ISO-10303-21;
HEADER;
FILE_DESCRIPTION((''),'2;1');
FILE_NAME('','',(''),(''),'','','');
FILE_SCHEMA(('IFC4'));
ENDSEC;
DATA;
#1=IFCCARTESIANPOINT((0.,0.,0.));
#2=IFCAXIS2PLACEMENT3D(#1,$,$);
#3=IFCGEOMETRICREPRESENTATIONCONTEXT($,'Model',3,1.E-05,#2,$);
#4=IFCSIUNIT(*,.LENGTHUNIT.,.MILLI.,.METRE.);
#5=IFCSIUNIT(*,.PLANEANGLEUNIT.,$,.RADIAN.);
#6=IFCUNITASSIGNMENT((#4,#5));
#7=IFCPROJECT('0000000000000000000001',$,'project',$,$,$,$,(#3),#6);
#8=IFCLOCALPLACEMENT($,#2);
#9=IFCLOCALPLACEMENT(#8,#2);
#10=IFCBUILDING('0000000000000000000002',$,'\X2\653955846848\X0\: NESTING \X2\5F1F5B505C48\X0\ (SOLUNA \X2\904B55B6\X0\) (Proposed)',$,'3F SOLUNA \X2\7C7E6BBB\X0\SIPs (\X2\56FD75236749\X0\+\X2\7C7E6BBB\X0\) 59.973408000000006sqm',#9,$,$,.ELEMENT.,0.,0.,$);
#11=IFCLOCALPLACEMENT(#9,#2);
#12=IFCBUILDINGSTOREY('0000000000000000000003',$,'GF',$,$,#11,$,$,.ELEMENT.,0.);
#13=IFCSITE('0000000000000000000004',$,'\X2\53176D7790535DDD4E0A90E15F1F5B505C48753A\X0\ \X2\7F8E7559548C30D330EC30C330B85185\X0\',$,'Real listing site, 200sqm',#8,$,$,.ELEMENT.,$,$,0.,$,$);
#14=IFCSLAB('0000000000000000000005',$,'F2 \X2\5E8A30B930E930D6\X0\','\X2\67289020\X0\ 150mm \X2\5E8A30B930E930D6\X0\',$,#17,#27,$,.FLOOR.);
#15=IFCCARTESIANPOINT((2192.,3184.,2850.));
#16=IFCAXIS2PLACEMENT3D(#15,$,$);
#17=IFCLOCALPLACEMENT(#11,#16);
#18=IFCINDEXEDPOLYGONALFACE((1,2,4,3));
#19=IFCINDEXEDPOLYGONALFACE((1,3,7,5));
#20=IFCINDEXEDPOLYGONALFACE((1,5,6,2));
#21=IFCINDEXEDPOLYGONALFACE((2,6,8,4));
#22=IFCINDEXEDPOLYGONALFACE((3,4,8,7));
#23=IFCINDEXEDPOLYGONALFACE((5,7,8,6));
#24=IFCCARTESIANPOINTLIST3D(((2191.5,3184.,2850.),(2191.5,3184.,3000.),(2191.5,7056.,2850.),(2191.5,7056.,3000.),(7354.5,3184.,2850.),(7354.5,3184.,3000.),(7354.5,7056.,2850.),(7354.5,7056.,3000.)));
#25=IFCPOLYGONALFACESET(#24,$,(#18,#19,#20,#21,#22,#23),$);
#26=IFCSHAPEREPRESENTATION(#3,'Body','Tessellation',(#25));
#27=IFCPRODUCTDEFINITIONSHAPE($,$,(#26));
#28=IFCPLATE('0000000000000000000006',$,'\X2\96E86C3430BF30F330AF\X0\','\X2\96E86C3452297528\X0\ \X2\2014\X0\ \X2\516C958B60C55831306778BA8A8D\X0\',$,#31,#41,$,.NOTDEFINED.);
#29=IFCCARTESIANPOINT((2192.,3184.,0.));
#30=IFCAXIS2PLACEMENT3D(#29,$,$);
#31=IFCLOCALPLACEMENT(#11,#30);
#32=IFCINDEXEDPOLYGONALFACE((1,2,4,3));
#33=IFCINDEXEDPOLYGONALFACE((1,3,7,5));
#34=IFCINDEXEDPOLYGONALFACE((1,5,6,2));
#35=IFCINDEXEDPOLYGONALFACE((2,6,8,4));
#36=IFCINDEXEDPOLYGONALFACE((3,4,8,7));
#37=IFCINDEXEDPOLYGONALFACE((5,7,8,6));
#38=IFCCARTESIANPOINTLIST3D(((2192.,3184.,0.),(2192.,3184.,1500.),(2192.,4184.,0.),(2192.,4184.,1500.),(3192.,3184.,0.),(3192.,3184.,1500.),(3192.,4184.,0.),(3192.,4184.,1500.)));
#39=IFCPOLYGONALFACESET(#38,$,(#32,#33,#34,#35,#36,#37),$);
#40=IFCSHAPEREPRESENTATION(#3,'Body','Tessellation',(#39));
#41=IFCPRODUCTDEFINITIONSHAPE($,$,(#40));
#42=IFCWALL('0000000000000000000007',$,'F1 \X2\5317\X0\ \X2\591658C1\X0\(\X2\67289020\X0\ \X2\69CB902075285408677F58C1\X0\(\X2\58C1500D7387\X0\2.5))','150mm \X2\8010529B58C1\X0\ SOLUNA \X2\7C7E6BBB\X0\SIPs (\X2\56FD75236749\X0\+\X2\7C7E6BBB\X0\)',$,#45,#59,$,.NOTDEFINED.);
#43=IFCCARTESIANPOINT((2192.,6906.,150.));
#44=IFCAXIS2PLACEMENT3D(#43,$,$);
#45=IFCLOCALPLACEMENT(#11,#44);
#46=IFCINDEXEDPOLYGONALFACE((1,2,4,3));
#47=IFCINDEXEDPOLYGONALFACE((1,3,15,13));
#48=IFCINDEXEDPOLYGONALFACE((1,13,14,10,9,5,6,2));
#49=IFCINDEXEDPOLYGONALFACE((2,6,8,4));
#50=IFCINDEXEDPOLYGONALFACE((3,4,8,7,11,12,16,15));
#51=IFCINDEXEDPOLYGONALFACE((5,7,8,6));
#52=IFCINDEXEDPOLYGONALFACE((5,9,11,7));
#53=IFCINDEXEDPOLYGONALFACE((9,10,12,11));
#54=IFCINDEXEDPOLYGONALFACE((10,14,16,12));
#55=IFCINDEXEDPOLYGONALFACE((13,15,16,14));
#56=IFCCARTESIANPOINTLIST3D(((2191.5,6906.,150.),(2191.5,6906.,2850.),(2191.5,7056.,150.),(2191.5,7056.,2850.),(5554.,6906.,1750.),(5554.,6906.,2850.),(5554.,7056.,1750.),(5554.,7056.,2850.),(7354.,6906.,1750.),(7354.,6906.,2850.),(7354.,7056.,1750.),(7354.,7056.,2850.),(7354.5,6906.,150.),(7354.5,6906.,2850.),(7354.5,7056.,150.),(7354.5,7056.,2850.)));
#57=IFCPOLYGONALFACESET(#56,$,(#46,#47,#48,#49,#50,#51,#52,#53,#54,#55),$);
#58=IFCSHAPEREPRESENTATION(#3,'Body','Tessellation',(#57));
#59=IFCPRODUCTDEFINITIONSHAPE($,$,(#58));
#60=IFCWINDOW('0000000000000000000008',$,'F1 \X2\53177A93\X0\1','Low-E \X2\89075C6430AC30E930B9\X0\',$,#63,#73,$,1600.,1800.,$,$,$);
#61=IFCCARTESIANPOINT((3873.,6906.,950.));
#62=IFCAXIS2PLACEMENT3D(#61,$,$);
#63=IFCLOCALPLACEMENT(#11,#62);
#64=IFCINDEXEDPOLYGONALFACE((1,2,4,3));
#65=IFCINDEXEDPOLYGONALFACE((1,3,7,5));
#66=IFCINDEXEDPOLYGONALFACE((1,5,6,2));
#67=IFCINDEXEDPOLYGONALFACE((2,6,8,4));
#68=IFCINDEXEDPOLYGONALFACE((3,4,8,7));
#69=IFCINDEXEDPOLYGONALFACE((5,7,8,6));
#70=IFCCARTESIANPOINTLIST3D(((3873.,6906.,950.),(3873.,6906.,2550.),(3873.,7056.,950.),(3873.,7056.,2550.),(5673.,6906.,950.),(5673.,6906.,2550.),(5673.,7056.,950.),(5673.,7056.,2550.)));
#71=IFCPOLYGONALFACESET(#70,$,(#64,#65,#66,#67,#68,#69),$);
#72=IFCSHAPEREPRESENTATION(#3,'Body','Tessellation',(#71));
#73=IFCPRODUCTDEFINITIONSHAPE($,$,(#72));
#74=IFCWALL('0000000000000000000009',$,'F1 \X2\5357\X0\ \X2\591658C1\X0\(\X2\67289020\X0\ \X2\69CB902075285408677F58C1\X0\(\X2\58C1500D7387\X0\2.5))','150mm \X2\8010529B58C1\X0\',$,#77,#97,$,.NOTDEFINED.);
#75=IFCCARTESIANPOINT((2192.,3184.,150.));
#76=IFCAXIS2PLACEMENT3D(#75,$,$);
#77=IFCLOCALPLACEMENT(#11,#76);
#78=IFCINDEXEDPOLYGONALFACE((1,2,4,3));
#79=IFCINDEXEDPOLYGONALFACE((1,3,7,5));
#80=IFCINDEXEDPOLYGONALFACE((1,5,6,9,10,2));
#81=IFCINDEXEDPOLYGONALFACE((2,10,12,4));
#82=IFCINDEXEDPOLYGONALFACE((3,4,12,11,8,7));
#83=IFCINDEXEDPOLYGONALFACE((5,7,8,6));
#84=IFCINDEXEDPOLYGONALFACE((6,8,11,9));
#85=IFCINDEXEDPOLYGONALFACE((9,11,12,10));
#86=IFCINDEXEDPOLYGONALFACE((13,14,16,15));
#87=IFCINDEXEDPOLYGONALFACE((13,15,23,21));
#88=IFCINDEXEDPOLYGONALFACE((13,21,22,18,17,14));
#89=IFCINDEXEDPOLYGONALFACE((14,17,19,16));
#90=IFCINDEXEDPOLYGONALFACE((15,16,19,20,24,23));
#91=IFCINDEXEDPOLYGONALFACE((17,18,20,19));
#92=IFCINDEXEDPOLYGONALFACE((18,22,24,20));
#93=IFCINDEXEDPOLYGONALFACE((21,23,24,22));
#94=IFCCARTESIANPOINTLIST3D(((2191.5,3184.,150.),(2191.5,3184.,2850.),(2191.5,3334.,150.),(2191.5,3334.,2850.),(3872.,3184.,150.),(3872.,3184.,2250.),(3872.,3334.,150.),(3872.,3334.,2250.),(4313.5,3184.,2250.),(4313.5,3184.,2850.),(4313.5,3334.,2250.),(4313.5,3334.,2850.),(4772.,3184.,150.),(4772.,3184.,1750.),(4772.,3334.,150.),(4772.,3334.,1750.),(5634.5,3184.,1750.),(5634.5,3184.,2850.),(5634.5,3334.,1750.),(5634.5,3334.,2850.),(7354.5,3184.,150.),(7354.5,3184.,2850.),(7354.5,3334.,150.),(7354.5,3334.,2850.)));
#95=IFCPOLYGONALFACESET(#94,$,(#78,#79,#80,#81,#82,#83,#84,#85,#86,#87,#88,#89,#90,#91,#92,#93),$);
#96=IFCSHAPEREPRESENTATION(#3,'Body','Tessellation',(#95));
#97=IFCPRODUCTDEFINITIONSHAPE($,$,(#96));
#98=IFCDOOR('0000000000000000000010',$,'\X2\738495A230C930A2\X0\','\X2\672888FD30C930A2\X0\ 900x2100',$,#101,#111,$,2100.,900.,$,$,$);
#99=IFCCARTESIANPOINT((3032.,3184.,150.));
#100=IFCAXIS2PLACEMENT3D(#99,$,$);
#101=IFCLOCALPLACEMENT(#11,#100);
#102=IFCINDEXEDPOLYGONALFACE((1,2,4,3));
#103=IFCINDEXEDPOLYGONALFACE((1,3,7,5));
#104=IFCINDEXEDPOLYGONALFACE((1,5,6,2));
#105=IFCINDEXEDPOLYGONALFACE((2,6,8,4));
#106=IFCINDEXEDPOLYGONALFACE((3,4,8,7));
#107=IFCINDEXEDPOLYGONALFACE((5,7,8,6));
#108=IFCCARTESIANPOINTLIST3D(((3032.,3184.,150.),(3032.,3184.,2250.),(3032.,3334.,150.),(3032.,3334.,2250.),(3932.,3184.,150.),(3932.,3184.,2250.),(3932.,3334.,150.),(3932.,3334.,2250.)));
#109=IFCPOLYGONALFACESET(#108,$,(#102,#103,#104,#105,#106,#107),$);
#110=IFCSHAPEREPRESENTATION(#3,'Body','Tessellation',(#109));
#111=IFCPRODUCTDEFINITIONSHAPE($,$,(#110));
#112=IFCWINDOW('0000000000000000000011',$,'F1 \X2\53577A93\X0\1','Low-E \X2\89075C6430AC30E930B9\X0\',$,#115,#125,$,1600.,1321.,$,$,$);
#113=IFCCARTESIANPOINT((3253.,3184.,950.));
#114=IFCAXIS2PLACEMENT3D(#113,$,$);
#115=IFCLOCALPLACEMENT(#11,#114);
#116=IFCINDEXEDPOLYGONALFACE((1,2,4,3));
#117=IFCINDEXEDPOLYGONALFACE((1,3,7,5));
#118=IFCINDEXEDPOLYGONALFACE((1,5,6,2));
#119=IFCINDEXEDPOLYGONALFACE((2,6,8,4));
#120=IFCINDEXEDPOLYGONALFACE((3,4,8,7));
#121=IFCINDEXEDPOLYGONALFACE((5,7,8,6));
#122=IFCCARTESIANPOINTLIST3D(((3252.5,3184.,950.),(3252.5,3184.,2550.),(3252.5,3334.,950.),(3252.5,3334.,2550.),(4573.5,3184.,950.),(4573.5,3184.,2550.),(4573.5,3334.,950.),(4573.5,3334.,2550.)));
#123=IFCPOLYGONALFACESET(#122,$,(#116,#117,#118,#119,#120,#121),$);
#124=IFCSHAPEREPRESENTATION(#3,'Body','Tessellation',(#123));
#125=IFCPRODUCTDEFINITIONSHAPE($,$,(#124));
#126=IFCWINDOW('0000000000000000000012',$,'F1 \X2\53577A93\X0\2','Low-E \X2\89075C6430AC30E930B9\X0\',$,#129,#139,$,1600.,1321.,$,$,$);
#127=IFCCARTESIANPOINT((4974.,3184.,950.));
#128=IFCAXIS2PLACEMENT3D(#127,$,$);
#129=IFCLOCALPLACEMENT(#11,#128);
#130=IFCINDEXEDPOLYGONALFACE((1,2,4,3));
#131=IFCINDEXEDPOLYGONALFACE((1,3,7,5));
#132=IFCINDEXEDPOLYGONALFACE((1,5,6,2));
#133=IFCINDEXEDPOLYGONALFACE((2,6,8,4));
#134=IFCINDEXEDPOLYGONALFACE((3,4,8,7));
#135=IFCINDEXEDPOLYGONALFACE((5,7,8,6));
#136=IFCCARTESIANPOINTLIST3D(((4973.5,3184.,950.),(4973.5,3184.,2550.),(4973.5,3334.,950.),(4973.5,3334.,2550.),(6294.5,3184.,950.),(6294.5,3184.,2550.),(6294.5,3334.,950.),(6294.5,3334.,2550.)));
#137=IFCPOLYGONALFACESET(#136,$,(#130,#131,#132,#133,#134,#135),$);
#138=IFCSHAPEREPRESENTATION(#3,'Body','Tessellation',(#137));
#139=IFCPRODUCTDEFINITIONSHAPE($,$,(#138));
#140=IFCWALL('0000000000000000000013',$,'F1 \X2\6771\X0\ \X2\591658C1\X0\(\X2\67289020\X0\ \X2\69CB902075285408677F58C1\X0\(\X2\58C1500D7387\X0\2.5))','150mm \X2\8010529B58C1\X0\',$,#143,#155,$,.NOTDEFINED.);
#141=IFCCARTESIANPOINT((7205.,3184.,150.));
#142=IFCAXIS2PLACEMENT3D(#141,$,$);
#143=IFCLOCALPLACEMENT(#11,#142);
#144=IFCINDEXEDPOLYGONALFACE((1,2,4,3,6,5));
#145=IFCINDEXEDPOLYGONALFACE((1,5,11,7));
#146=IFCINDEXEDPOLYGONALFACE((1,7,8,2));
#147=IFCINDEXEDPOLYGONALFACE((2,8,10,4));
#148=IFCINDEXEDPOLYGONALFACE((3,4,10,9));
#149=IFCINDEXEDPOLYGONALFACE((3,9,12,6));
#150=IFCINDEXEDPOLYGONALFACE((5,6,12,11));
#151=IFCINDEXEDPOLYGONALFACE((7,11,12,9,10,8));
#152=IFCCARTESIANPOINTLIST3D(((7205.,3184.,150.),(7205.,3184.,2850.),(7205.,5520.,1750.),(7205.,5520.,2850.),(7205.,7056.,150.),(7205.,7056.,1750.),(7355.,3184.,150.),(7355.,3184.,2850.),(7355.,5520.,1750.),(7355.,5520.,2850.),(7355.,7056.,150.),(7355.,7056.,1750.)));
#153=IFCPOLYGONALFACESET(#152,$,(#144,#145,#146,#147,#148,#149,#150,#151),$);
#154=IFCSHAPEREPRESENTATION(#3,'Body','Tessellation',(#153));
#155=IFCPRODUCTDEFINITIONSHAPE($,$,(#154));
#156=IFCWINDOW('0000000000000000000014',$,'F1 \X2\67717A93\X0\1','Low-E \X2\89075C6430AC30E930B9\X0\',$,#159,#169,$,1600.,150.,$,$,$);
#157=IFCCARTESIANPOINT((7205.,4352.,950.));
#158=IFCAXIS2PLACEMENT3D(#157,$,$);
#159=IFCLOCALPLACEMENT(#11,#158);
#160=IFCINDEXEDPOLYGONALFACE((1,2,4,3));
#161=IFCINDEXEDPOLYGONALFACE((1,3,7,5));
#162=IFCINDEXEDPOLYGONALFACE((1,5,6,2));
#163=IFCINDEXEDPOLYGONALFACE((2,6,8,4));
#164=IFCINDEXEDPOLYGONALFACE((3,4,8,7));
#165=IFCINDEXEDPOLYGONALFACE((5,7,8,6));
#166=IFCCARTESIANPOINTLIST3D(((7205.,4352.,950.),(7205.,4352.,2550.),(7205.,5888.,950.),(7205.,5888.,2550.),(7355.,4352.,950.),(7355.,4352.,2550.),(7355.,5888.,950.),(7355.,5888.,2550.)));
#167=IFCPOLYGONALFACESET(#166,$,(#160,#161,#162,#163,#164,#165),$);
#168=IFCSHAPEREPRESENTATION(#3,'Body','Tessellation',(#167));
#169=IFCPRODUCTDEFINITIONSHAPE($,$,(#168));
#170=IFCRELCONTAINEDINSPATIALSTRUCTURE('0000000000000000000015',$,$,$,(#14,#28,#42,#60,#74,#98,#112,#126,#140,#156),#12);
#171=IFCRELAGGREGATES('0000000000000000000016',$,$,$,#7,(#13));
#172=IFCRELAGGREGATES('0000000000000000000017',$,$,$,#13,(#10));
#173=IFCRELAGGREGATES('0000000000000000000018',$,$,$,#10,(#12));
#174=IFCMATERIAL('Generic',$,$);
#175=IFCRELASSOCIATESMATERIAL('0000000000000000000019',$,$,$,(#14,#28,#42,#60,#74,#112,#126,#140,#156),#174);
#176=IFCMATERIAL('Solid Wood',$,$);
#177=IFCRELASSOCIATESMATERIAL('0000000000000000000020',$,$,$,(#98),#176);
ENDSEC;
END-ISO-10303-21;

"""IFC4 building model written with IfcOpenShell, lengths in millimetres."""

from ifc_helpers import new_model, si_unit, frame, frame_2d, origin, place, context, project, spatial, rectangle, extrude, material, element, fill, save


model = new_model("IFC4")

# Units and contexts
model_context = context("Model", 3, precision=1e-05, world=origin())
ifc_project = project(units=[si_unit("LENGTHUNIT", "METRE", prefix="MILLI"), si_unit("PLANEANGLEUNIT", "RADIAN")], contexts=[model_context])

# Site, building, storey
site_placement = place(None, origin())
site = spatial("IfcSite", under=ifc_project, at=site_placement, Name="北海道川上郡弟子屈町 美留和ビレッジ内", ObjectType="Real listing site, 200sqm", CompositionType="ELEMENT", RefElevation=0.0)
building_placement = place(site_placement, origin())
building = spatial("IfcBuilding", under=site, at=building_placement, Name="改善案: NESTING 弟子屈 (SOLUNA 運営) (Proposed)", ObjectType="3F SOLUNA 籾殻SIPs (国産杉+籾殻) 59.973408000000006sqm", CompositionType="ELEMENT", ElevationOfRefHeight=0.0, ElevationOfTerrain=0.0)
storey_placement = place(building_placement, origin())
storey = spatial("IfcBuildingStorey", under=building, at=storey_placement, Name="GF", CompositionType="ELEMENT", Elevation=0.0)

# Slab
ifc_material_1 = material(Name="Generic")
slab_1_placement = place(storey_placement, frame((2192.0, 3184.0, 2850.0)))
element("IfcSlab", 1, at=slab_1_placement, inside=storey, material=ifc_material_1, Name="F2 床スラブ", Description="木造 150mm 床スラブ", PredefinedType="FLOOR", context=model_context, shape_type="SweptSolid", body=[
    extrude(rectangle(XDim=5163.0, YDim=3872.0, at=frame_2d((2581.0, 1936.0))), frame((2192.0, 3184.0, 2850.0)), (0.0, 0.0, 1.0), 150.0),
])

# Plate
plate_placement = place(storey_placement, frame((2192.0, 3184.0, 0.0)))
element("IfcPlate", 2, at=plate_placement, inside=storey, material=ifc_material_1, Name="雨水タンク", Description="雨水利用 — 公開情報で確認", PredefinedType="NOTDEFINED", context=model_context, shape_type="SweptSolid", body=[
    extrude(rectangle(XDim=1000.0, YDim=1000.0, at=frame_2d((500.0, 500.0))), frame((2192.0, 3184.0, 0.0)), (0.0, 0.0, 1.0), 1500.0),
])

# Wall, opening, window
wall_1_placement = place(storey_placement, frame((2192.0, 6906.0, 150.0)))
wall_1 = element("IfcWall", 3, at=wall_1_placement, inside=storey, material=ifc_material_1, Name="F1 北 外壁(木造 構造用合板壁(壁倍率2.5))", Description="150mm 耐力壁 SOLUNA 籾殻SIPs (国産杉+籾殻)", PredefinedType="NOTDEFINED", context=model_context, shape_type="SweptSolid", body=[
    extrude(rectangle(XDim=5163.0, YDim=150.0, at=frame_2d((2581.0, 75.0))), frame((2192.0, 6906.0, 150.0)), (0.0, 0.0, 1.0), 2700.0),
])
opening_1_placement = place(storey_placement, frame((3873.0, 6906.0, 950.0)))
opening_1 = element("IfcOpeningElement", 4, at=opening_1_placement, cuts=wall_1, PredefinedType="NOTDEFINED", context=model_context, shape_type="SweptSolid", body=[
    extrude(rectangle(XDim=1800.0, YDim=150.0, at=frame_2d((900.0, 75.0))), frame((3873.0, 6906.0, 950.0)), (0.0, 0.0, 1.0), 1600.0),
])
window_1_placement = place(storey_placement, frame((3873.0, 6906.0, 950.0)))
window_1 = element("IfcWindow", 5, at=window_1_placement, inside=storey, material=ifc_material_1, Name="F1 北窓1", Description="Low-E 複層ガラス", OverallHeight=1600.0, OverallWidth=1800.0, context=model_context, shape_type="SweptSolid", body=[
    extrude(rectangle(XDim=1800.0, YDim=150.0, at=frame_2d((900.0, 75.0))), frame((3873.0, 6906.0, 950.0)), (0.0, 0.0, 1.0), 1600.0),
])
fill(opening_1, window_1)

# Wall, openings, door, windows
wall_2_placement = place(storey_placement, frame((2192.0, 3184.0, 150.0)))
wall_2 = element("IfcWall", 6, at=wall_2_placement, inside=storey, material=ifc_material_1, Name="F1 南 外壁(木造 構造用合板壁(壁倍率2.5))", Description="150mm 耐力壁", PredefinedType="NOTDEFINED", context=model_context, shape_type="SweptSolid", body=[
    extrude(rectangle(XDim=5163.0, YDim=150.0, at=frame_2d((2581.0, 75.0))), frame((2192.0, 3184.0, 150.0)), (0.0, 0.0, 1.0), 2700.0),
])
opening_2_placement = place(storey_placement, frame((3032.0, 3184.0, 150.0)))
opening_2 = element("IfcOpeningElement", 7, at=opening_2_placement, cuts=wall_2, PredefinedType="NOTDEFINED", context=model_context, shape_type="SweptSolid", body=[
    extrude(rectangle(XDim=900.0, YDim=150.0, at=frame_2d((450.0, 75.0))), frame((3032.0, 3184.0, 150.0)), (0.0, 0.0, 1.0), 2100.0),
])
opening_3_placement = place(storey_placement, frame((3253.0, 3184.0, 950.0)))
opening_3 = element("IfcOpeningElement", 8, at=opening_3_placement, cuts=wall_2, PredefinedType="NOTDEFINED", context=model_context, shape_type="SweptSolid", body=[
    extrude(rectangle(XDim=1321.0, YDim=150.0, at=frame_2d((660.0, 75.0))), frame((3253.0, 3184.0, 950.0)), (0.0, 0.0, 1.0), 1600.0),
])
opening_4_placement = place(storey_placement, frame((4974.0, 3184.0, 950.0)))
opening_4 = element("IfcOpeningElement", 9, at=opening_4_placement, cuts=wall_2, PredefinedType="NOTDEFINED", context=model_context, shape_type="SweptSolid", body=[
    extrude(rectangle(XDim=1321.0, YDim=150.0, at=frame_2d((660.0, 75.0))), frame((4974.0, 3184.0, 950.0)), (0.0, 0.0, 1.0), 1600.0),
])
ifc_material_2 = material(Name="Solid Wood")
door_placement = place(storey_placement, frame((3032.0, 3184.0, 150.0)))
door = element("IfcDoor", 10, at=door_placement, inside=storey, material=ifc_material_2, Name="玄関ドア", Description="木製ドア 900x2100", OverallHeight=2100.0, OverallWidth=900.0, context=model_context, shape_type="SweptSolid", body=[
    extrude(rectangle(XDim=900.0, YDim=150.0, at=frame_2d((450.0, 75.0))), frame((3032.0, 3184.0, 150.0)), (0.0, 0.0, 1.0), 2100.0),
])
fill(opening_2, door)
window_2_placement = place(storey_placement, frame((3253.0, 3184.0, 950.0)))
window_2 = element("IfcWindow", 11, at=window_2_placement, inside=storey, material=ifc_material_1, Name="F1 南窓1", Description="Low-E 複層ガラス", OverallHeight=1600.0, OverallWidth=1321.0, context=model_context, shape_type="SweptSolid", body=[
    extrude(rectangle(XDim=1321.0, YDim=150.0, at=frame_2d((660.0, 75.0))), frame((3253.0, 3184.0, 950.0)), (0.0, 0.0, 1.0), 1600.0),
])
fill(opening_3, window_2)
window_3_placement = place(storey_placement, frame((4974.0, 3184.0, 950.0)))
window_3 = element("IfcWindow", 12, at=window_3_placement, inside=storey, material=ifc_material_1, Name="F1 南窓2", Description="Low-E 複層ガラス", OverallHeight=1600.0, OverallWidth=1321.0, context=model_context, shape_type="SweptSolid", body=[
    extrude(rectangle(XDim=1321.0, YDim=150.0, at=frame_2d((660.0, 75.0))), frame((4974.0, 3184.0, 950.0)), (0.0, 0.0, 1.0), 1600.0),
])
fill(opening_4, window_3)

# Wall, opening, window
wall_3_placement = place(storey_placement, frame((7205.0, 3184.0, 150.0)))
wall_3 = element("IfcWall", 13, at=wall_3_placement, inside=storey, material=ifc_material_1, Name="F1 東 外壁(木造 構造用合板壁(壁倍率2.5))", Description="150mm 耐力壁", PredefinedType="NOTDEFINED", context=model_context, shape_type="SweptSolid", body=[
    extrude(rectangle(XDim=150.0, YDim=3872.0, at=frame_2d((75.0, 1936.0))), frame((7205.0, 3184.0, 150.0)), (0.0, 0.0, 1.0), 2700.0),
])
opening_5_placement = place(storey_placement, frame((7205.0, 4352.0, 950.0)))
opening_5 = element("IfcOpeningElement", 14, at=opening_5_placement, cuts=wall_3, PredefinedType="NOTDEFINED", context=model_context, shape_type="SweptSolid", body=[
    extrude(rectangle(XDim=150.0, YDim=1536.0, at=frame_2d((75.0, 768.0))), frame((7205.0, 4352.0, 950.0)), (0.0, 0.0, 1.0), 1600.0),
])
window_4_placement = place(storey_placement, frame((7205.0, 4352.0, 950.0)))
window_4 = element("IfcWindow", 15, at=window_4_placement, inside=storey, material=ifc_material_1, Name="F1 東窓1", Description="Low-E 複層ガラス", OverallHeight=1600.0, OverallWidth=150.0, context=model_context, shape_type="SweptSolid", body=[
    extrude(rectangle(XDim=150.0, YDim=1536.0, at=frame_2d((75.0, 768.0))), frame((7205.0, 4352.0, 950.0)), (0.0, 0.0, 1.0), 1600.0),
])
fill(opening_5, window_4)

save(model, "model.ifc")
